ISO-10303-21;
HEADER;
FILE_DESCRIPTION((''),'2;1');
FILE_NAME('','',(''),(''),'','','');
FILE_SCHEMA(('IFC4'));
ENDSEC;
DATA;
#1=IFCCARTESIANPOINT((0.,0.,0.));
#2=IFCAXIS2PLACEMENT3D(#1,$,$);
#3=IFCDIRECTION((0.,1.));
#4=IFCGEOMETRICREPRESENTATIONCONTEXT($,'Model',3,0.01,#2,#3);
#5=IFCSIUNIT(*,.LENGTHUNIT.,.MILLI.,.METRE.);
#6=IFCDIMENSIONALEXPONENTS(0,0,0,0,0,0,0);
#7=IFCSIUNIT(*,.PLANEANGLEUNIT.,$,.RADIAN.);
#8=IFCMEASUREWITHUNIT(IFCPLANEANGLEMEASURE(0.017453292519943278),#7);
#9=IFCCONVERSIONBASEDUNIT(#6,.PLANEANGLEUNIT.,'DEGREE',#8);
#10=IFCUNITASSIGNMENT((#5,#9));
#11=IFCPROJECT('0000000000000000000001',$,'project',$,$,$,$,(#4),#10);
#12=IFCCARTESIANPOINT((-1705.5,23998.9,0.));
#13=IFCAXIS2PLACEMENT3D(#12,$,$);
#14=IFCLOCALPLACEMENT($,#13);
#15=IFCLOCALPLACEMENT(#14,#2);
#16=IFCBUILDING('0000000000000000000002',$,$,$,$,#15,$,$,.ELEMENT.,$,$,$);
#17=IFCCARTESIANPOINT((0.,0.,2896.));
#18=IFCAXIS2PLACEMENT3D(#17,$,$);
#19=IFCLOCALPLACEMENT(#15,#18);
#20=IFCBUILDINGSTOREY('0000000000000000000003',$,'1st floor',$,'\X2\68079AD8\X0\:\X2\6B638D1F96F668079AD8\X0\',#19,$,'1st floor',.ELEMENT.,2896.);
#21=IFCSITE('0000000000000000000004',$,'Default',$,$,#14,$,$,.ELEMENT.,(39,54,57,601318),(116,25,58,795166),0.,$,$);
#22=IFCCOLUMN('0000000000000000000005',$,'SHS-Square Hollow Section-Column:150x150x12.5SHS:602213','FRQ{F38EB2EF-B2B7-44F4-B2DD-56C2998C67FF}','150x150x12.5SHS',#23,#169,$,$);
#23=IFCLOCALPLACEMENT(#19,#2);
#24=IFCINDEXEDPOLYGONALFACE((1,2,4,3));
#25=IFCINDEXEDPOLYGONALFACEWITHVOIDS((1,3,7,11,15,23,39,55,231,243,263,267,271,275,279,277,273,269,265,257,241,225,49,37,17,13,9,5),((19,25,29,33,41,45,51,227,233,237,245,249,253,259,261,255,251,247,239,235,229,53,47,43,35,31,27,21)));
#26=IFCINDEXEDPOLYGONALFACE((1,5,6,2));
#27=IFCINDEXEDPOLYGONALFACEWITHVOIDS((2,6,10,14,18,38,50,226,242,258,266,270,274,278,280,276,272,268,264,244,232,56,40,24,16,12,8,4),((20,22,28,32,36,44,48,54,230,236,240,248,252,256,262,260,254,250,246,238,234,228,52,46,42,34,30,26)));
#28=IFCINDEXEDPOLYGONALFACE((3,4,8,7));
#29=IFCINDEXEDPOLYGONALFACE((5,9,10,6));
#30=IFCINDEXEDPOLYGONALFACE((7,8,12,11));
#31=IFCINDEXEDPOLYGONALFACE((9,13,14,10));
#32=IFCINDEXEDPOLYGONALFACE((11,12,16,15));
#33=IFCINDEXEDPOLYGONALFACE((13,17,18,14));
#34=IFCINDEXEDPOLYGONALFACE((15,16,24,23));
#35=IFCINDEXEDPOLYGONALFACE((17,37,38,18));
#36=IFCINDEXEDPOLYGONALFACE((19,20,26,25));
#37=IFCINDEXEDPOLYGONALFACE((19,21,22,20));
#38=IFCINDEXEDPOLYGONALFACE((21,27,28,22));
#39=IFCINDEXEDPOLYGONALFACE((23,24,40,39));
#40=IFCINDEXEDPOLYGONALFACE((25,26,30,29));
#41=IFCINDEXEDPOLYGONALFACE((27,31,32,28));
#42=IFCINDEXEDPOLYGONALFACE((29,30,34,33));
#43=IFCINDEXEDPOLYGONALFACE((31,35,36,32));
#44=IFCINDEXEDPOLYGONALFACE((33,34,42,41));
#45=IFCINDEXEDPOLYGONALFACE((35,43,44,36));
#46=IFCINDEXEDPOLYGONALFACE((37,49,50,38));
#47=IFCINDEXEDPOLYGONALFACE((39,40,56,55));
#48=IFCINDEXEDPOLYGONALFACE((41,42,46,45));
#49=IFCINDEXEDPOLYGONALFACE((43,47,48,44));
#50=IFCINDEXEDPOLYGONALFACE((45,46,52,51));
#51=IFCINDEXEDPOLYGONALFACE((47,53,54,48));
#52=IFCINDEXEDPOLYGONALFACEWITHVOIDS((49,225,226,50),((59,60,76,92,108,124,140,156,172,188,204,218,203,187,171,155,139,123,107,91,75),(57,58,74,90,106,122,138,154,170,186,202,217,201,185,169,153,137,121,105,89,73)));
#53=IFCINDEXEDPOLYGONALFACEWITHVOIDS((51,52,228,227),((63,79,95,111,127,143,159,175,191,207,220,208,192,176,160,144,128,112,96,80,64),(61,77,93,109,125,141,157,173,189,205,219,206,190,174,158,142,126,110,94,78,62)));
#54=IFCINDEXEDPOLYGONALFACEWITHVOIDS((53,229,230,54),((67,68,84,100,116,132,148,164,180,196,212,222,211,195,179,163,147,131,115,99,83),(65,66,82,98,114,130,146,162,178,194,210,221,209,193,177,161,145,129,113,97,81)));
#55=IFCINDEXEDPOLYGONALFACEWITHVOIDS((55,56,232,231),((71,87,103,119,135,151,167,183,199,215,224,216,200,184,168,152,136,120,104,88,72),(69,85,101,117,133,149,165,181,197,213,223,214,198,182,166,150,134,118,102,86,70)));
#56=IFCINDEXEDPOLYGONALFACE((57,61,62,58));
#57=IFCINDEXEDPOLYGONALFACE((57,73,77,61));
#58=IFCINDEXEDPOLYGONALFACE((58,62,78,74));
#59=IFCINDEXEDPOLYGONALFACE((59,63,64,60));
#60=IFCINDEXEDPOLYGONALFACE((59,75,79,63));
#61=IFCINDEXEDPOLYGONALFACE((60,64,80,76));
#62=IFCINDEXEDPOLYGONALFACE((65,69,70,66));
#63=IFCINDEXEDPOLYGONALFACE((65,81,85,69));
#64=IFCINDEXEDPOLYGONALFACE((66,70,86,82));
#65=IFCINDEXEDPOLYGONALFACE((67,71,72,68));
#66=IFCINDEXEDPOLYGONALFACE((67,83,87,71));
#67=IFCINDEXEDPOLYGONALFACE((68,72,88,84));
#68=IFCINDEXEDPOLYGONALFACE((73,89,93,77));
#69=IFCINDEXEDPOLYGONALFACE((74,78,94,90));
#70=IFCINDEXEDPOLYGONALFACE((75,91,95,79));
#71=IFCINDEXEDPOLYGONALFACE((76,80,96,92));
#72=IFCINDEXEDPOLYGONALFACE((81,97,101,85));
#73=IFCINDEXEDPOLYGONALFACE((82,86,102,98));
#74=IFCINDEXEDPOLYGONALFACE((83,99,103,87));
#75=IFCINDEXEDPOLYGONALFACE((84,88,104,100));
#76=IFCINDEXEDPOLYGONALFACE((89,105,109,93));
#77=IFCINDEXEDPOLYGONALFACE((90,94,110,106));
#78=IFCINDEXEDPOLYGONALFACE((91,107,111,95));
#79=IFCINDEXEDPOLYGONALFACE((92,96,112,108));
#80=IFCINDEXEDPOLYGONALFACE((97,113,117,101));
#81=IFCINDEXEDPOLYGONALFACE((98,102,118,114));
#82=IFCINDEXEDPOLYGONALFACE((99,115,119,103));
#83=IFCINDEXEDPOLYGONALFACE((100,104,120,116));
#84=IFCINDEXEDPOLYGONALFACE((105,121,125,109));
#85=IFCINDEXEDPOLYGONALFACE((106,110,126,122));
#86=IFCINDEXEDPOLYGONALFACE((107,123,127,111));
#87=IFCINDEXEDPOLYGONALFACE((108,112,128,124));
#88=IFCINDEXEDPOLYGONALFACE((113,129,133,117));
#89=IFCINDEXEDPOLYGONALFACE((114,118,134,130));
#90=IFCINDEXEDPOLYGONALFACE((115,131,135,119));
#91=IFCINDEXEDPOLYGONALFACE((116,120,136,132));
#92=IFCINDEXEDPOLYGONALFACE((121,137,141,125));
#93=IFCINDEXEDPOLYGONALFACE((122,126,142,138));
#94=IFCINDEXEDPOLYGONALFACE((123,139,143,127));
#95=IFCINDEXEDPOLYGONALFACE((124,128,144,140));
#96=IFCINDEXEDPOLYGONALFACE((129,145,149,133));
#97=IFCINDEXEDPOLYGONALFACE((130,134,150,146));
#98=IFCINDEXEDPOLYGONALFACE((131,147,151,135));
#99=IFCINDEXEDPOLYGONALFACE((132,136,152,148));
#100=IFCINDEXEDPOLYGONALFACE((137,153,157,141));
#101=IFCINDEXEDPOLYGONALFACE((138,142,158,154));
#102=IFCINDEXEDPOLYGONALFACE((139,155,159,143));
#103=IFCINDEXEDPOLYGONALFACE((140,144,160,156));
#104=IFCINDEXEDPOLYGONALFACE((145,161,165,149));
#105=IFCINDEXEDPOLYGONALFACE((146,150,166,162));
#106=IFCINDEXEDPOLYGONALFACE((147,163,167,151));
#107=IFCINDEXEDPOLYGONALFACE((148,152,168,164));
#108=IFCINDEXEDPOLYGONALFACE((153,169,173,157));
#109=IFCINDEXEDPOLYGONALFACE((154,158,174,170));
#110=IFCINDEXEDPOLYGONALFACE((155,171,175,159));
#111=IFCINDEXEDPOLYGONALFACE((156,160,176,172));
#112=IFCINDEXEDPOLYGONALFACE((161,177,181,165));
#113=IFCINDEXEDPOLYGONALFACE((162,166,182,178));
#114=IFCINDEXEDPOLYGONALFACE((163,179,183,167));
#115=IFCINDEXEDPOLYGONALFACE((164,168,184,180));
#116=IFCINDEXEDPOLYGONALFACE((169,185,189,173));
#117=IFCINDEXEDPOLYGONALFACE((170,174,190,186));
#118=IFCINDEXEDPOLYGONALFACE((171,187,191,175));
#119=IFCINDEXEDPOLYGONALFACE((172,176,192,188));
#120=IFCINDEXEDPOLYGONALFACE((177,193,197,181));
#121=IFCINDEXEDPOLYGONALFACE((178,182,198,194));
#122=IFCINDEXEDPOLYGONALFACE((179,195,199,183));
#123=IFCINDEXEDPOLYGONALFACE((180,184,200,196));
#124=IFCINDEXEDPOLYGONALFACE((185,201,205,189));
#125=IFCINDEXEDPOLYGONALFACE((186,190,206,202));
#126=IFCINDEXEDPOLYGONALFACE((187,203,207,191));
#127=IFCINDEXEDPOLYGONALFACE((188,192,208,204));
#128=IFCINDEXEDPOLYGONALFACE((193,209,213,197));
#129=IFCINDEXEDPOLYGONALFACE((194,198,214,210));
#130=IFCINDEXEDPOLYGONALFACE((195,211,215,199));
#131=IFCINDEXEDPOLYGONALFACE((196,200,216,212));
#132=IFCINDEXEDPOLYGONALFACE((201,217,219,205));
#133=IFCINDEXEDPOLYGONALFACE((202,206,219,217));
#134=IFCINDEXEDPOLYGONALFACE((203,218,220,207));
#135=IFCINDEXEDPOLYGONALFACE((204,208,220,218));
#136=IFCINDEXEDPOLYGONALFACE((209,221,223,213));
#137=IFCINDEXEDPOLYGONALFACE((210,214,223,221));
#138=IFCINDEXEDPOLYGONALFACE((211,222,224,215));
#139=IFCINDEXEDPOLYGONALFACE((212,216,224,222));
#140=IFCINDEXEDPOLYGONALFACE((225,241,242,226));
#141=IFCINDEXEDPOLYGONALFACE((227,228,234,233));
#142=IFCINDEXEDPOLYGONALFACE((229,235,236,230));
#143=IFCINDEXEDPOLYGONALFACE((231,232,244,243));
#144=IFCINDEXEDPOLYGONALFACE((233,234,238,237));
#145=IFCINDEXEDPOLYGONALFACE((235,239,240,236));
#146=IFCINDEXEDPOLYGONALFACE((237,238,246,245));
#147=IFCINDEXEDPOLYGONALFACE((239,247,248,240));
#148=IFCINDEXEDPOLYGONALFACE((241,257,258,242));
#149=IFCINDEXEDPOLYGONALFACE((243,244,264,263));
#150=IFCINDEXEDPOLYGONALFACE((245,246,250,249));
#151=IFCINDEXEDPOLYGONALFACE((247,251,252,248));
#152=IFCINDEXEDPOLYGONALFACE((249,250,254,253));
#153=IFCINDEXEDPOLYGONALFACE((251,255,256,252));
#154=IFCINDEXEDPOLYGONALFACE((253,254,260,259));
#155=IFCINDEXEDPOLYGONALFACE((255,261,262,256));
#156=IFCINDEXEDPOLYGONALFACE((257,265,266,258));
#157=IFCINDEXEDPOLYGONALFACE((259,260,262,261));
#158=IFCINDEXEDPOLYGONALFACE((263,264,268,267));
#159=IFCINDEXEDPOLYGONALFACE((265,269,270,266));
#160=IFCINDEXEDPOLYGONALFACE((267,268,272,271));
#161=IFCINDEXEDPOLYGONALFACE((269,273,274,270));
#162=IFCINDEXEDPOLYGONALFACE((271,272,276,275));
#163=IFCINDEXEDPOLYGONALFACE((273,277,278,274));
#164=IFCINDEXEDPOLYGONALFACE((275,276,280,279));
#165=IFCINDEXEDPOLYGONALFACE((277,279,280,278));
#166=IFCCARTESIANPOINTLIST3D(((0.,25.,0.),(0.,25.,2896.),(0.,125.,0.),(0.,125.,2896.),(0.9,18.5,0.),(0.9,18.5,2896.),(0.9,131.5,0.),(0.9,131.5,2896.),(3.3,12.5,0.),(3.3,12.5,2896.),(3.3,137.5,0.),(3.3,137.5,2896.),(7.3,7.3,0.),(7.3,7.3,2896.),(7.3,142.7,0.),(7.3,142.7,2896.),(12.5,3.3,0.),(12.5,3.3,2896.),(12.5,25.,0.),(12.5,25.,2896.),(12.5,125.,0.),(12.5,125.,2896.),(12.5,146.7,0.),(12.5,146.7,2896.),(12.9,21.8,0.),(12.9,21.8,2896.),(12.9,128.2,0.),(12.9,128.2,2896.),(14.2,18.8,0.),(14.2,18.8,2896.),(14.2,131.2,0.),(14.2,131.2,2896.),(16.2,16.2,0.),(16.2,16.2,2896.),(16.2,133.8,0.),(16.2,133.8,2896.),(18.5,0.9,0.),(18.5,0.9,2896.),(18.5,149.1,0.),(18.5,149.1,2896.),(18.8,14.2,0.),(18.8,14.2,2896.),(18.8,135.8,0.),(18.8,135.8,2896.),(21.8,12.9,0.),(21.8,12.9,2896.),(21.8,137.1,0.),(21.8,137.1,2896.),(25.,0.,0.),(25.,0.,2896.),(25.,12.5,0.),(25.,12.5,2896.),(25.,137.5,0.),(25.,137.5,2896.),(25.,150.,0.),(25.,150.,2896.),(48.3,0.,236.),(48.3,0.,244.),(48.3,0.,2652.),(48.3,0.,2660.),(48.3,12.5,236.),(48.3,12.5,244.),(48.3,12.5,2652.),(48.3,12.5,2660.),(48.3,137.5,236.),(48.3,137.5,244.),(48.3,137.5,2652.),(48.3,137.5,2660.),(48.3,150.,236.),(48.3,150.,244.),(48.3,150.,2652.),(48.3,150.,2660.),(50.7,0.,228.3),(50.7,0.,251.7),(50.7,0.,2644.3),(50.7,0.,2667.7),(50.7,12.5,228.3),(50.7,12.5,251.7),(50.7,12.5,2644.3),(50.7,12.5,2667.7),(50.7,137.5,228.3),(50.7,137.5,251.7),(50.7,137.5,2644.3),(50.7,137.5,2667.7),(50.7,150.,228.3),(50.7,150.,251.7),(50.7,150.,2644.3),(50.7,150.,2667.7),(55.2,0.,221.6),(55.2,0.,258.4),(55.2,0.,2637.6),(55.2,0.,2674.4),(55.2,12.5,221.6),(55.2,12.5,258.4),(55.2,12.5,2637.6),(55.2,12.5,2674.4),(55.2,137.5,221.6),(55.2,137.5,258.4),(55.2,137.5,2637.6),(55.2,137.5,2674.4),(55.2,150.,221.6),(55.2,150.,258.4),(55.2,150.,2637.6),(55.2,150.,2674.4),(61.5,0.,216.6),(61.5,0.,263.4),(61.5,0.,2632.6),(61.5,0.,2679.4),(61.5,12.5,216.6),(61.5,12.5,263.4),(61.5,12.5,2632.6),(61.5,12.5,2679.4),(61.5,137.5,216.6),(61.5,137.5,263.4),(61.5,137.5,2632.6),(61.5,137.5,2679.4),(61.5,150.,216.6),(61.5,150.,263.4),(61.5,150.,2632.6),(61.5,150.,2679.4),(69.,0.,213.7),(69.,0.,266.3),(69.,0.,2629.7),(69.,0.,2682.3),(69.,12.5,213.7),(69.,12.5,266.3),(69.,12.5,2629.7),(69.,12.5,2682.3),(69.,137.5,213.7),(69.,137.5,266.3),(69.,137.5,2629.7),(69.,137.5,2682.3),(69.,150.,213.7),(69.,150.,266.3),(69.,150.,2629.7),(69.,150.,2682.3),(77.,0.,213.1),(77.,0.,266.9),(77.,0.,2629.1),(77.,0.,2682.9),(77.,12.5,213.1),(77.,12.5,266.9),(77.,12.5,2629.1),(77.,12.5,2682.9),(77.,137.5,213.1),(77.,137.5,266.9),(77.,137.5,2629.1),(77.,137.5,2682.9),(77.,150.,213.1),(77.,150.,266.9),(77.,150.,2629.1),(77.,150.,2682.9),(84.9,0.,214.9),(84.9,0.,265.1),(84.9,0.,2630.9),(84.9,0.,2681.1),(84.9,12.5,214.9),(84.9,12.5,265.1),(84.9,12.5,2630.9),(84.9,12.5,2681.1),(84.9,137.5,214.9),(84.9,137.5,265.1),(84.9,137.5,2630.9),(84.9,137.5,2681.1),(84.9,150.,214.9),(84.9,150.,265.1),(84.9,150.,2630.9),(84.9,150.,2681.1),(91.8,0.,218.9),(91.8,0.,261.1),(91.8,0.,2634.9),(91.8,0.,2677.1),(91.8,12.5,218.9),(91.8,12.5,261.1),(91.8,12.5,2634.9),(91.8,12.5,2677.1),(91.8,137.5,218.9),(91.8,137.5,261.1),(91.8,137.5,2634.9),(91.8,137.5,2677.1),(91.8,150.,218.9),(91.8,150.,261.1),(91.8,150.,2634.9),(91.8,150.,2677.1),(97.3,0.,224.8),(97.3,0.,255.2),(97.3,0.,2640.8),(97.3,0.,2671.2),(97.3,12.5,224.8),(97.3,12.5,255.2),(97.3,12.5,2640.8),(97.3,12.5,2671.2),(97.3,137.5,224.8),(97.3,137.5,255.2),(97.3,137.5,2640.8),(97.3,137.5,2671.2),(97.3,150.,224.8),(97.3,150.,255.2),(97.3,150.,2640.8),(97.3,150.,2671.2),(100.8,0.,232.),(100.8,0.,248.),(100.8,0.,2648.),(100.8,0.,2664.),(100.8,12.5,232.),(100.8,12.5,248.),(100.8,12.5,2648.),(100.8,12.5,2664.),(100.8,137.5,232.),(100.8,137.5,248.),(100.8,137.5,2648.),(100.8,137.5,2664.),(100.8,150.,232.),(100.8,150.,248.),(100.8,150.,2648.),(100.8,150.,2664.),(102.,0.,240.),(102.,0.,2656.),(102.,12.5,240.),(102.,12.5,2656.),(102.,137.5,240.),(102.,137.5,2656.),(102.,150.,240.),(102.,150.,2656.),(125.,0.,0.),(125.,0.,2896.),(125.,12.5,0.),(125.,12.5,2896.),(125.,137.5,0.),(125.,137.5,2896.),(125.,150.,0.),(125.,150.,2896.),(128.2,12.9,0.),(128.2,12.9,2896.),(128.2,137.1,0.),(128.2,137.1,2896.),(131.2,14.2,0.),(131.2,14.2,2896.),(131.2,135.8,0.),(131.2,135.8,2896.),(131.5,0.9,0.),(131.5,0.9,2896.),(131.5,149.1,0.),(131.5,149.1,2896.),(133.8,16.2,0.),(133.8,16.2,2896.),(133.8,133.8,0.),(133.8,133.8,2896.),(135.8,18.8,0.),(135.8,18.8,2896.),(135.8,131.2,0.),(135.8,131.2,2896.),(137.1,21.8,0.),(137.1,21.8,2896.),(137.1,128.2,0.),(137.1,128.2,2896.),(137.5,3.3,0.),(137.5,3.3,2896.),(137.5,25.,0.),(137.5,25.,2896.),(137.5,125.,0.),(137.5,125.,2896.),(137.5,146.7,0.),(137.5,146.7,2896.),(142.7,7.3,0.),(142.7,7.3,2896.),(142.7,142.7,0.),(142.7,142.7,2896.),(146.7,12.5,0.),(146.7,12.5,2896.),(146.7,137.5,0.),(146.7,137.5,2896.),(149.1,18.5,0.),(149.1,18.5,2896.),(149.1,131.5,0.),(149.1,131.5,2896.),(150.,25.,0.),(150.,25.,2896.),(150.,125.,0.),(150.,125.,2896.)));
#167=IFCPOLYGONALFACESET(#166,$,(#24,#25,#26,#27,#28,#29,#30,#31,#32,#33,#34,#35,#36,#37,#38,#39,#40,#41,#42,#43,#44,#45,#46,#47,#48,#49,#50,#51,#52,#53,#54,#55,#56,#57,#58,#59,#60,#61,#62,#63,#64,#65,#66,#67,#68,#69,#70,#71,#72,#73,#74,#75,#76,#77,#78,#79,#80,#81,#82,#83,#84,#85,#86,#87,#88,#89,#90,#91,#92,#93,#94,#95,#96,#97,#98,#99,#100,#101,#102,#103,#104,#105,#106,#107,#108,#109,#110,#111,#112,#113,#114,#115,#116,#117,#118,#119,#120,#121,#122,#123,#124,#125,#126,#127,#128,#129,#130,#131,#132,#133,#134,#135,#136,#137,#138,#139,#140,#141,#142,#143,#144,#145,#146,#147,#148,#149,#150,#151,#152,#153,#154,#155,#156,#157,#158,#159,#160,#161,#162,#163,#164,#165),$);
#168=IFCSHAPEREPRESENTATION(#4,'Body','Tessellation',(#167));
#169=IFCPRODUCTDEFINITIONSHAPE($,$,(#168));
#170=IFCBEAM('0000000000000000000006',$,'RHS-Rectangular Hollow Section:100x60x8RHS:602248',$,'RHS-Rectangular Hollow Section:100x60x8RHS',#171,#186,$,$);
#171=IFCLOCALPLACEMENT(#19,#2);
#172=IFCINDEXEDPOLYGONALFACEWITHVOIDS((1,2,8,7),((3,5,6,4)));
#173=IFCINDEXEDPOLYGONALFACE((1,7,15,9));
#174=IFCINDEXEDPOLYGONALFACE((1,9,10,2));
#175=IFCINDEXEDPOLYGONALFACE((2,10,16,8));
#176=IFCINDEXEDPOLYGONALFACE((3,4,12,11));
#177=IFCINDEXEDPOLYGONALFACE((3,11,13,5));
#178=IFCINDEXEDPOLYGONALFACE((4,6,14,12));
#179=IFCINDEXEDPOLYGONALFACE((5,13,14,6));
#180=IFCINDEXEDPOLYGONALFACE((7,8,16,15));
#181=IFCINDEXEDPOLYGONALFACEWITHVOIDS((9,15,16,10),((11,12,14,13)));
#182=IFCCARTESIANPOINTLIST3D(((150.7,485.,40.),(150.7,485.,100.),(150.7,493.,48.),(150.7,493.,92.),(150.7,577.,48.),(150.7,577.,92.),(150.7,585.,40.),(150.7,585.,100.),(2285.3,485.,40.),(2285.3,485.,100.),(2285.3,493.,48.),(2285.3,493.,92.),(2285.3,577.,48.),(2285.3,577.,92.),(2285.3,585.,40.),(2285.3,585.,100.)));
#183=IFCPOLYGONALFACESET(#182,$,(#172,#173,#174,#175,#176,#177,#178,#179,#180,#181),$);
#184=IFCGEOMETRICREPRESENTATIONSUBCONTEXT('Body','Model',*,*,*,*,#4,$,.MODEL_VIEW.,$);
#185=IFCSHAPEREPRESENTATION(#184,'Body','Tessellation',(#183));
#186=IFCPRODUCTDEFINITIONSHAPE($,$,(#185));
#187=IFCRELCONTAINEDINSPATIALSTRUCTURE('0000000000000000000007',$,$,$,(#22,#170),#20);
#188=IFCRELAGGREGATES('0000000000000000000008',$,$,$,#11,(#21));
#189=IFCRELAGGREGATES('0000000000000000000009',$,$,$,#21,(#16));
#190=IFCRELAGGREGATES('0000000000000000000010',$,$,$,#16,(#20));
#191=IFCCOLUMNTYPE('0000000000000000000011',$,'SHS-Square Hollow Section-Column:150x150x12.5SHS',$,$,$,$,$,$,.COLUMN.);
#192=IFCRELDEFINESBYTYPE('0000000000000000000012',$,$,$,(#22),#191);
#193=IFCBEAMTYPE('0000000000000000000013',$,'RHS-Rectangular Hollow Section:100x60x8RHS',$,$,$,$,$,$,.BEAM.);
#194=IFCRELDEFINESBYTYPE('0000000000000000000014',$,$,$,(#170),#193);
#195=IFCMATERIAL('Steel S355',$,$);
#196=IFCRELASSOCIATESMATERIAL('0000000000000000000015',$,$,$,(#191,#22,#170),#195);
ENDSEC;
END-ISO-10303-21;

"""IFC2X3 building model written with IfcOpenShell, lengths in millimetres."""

from ifc_helpers import new_model, entity, si_unit, converted_unit, direction, frame, frame_2d, origin, origin_2d, place, context, subcontext, project, spatial, circle_curve, rectangle, hollow_rectangle, outline, extrude, boolean, material, type_object, element, save


model = new_model("IFC2X3")

# Units and contexts
model_context = context("Model", 3, precision=0.01, world=origin(), true_north=direction((0.0, 1.0)))
body_context = subcontext(model_context, "Body", "Model", "MODEL_VIEW")
ifc_project = project(units=[si_unit("LENGTHUNIT", "METRE", prefix="MILLI"), converted_unit("PLANEANGLEUNIT", "DEGREE", entity("IfcPlaneAngleMeasure", 0.017453292519943278), si_unit("PLANEANGLEUNIT", "RADIAN"), dimensions=[0, 0, 0, 0, 0, 0, 0])], contexts=[model_context])

# Site, building, storey
site_placement = place(None, frame((-1705.5, 23998.9, 0.0)))
site = spatial("IfcSite", under=ifc_project, at=site_placement, Name="Default", CompositionType="ELEMENT", RefLatitude=(39, 54, 57, 601318), RefLongitude=(116, 25, 58, 795166), RefElevation=0.0)
building_placement = place(site_placement, origin())
building = spatial("IfcBuilding", under=site, at=building_placement, CompositionType="ELEMENT")
storey_placement = place(building_placement, frame((0.0, 0.0, 2896.0)))
storey = spatial("IfcBuildingStorey", under=building, at=storey_placement, Name="1st floor", ObjectType="标高:正负零标高", LongName="1st floor", CompositionType="ELEMENT", Elevation=2896.0)

# Shared definitions
ifc_material_1 = material(Name="Steel S355")

# Column, openings
column_type_1 = type_object("IfcColumnType", Name="SHS-Square Hollow Section-Column:150x150x12.5SHS", PredefinedType="COLUMN", material=ifc_material_1)
column_1_placement = place(storey_placement, frame((75.0, 75.0, 2896.0), z_axis=(0.0, 0.0, 1.0), x_axis=(0.0, -1.0, 0.0)))
column_1 = element("IfcColumn", 1, at=column_1_placement, inside=storey, type_object=column_type_1, material=ifc_material_1, Name="SHS-Square Hollow Section-Column:150x150x12.5SHS:602213", Description="FRQ{F38EB2EF-B2B7-44F4-B2DD-56C2998C67FF}", ObjectType="150x150x12.5SHS", context=model_context, shape_type="SweptSolid", body=[
    extrude(hollow_rectangle(XDim=150.0, YDim=150.0, WallThickness=12.5, InnerFilletRadius=12.5, OuterFilletRadius=25.0, at=origin_2d()), origin(), (0.0, 0.0, -1.0), 2896.0),
])
opening_1_placement = place(column_1_placement, frame((-175.1, 0.0, -2896.0), z_axis=(1.0, 0.0, 0.0), x_axis=(0.0, 1.0, 0.0)))
element("IfcOpeningElement", 2, at=opening_1_placement, cuts=column_1, ObjectType="Opening", context=model_context, shape_type="SweptSolid", body=[
    extrude(outline(circle_curve(frame_2d((0.0, 240.0), x_axis=(1.0, 0.0)), 27.0)), origin(), (0.0, 0.0, 1.0), 350.2),
])
opening_2_placement = place(column_1_placement, frame((-175.1, 0.0, 0.0), z_axis=(1.0, 0.0, 0.0), x_axis=(0.0, 1.0, 0.0)))
element("IfcOpeningElement", 3, at=opening_2_placement, cuts=column_1, ObjectType="Opening", context=model_context, shape_type="SweptSolid", body=[
    extrude(outline(circle_curve(frame_2d((0.0, -240.0), x_axis=(1.0, 0.0)), 27.0)), origin(), (0.0, 0.0, 1.0), 350.2),
])

# Beam
beam_type_1 = type_object("IfcBeamType", Name="RHS-Rectangular Hollow Section:100x60x8RHS", PredefinedType="BEAM")
beam_1_placement = place(storey_placement, frame((150.7, 585.0, 70.0)))
element("IfcBeam", 4, at=beam_1_placement, inside=storey, type_object=beam_type_1, material=ifc_material_1, Name="RHS-Rectangular Hollow Section:100x60x8RHS:602248", ObjectType="RHS-Rectangular Hollow Section:100x60x8RHS", context=body_context, shape_type="SweptSolid", body=[
    boolean("DIFFERENCE", extrude(rectangle(XDim=60.0, YDim=100.0, at=frame_2d((0.0, 0.0), x_axis=(1.0, 0.0))), frame((0.0, -50.0, 0.0), z_axis=(1.0, 0.0, 0.0), x_axis=(0.0, 0.0, -1.0)), (0.0, 0.0, 1.0), 2134.6), extrude(rectangle(XDim=44.0, YDim=84.0, at=frame_2d((0.0, 0.0), x_axis=(0.0, 1.0))), frame((2134.6, -50.0, 0.0), z_axis=(-1.0, 0.0, 0.0), x_axis=(0.0, 1.0, 0.0)), (0.0, 0.0, 1.0), 2134.6)),
])

save(model, "model.ifc")
